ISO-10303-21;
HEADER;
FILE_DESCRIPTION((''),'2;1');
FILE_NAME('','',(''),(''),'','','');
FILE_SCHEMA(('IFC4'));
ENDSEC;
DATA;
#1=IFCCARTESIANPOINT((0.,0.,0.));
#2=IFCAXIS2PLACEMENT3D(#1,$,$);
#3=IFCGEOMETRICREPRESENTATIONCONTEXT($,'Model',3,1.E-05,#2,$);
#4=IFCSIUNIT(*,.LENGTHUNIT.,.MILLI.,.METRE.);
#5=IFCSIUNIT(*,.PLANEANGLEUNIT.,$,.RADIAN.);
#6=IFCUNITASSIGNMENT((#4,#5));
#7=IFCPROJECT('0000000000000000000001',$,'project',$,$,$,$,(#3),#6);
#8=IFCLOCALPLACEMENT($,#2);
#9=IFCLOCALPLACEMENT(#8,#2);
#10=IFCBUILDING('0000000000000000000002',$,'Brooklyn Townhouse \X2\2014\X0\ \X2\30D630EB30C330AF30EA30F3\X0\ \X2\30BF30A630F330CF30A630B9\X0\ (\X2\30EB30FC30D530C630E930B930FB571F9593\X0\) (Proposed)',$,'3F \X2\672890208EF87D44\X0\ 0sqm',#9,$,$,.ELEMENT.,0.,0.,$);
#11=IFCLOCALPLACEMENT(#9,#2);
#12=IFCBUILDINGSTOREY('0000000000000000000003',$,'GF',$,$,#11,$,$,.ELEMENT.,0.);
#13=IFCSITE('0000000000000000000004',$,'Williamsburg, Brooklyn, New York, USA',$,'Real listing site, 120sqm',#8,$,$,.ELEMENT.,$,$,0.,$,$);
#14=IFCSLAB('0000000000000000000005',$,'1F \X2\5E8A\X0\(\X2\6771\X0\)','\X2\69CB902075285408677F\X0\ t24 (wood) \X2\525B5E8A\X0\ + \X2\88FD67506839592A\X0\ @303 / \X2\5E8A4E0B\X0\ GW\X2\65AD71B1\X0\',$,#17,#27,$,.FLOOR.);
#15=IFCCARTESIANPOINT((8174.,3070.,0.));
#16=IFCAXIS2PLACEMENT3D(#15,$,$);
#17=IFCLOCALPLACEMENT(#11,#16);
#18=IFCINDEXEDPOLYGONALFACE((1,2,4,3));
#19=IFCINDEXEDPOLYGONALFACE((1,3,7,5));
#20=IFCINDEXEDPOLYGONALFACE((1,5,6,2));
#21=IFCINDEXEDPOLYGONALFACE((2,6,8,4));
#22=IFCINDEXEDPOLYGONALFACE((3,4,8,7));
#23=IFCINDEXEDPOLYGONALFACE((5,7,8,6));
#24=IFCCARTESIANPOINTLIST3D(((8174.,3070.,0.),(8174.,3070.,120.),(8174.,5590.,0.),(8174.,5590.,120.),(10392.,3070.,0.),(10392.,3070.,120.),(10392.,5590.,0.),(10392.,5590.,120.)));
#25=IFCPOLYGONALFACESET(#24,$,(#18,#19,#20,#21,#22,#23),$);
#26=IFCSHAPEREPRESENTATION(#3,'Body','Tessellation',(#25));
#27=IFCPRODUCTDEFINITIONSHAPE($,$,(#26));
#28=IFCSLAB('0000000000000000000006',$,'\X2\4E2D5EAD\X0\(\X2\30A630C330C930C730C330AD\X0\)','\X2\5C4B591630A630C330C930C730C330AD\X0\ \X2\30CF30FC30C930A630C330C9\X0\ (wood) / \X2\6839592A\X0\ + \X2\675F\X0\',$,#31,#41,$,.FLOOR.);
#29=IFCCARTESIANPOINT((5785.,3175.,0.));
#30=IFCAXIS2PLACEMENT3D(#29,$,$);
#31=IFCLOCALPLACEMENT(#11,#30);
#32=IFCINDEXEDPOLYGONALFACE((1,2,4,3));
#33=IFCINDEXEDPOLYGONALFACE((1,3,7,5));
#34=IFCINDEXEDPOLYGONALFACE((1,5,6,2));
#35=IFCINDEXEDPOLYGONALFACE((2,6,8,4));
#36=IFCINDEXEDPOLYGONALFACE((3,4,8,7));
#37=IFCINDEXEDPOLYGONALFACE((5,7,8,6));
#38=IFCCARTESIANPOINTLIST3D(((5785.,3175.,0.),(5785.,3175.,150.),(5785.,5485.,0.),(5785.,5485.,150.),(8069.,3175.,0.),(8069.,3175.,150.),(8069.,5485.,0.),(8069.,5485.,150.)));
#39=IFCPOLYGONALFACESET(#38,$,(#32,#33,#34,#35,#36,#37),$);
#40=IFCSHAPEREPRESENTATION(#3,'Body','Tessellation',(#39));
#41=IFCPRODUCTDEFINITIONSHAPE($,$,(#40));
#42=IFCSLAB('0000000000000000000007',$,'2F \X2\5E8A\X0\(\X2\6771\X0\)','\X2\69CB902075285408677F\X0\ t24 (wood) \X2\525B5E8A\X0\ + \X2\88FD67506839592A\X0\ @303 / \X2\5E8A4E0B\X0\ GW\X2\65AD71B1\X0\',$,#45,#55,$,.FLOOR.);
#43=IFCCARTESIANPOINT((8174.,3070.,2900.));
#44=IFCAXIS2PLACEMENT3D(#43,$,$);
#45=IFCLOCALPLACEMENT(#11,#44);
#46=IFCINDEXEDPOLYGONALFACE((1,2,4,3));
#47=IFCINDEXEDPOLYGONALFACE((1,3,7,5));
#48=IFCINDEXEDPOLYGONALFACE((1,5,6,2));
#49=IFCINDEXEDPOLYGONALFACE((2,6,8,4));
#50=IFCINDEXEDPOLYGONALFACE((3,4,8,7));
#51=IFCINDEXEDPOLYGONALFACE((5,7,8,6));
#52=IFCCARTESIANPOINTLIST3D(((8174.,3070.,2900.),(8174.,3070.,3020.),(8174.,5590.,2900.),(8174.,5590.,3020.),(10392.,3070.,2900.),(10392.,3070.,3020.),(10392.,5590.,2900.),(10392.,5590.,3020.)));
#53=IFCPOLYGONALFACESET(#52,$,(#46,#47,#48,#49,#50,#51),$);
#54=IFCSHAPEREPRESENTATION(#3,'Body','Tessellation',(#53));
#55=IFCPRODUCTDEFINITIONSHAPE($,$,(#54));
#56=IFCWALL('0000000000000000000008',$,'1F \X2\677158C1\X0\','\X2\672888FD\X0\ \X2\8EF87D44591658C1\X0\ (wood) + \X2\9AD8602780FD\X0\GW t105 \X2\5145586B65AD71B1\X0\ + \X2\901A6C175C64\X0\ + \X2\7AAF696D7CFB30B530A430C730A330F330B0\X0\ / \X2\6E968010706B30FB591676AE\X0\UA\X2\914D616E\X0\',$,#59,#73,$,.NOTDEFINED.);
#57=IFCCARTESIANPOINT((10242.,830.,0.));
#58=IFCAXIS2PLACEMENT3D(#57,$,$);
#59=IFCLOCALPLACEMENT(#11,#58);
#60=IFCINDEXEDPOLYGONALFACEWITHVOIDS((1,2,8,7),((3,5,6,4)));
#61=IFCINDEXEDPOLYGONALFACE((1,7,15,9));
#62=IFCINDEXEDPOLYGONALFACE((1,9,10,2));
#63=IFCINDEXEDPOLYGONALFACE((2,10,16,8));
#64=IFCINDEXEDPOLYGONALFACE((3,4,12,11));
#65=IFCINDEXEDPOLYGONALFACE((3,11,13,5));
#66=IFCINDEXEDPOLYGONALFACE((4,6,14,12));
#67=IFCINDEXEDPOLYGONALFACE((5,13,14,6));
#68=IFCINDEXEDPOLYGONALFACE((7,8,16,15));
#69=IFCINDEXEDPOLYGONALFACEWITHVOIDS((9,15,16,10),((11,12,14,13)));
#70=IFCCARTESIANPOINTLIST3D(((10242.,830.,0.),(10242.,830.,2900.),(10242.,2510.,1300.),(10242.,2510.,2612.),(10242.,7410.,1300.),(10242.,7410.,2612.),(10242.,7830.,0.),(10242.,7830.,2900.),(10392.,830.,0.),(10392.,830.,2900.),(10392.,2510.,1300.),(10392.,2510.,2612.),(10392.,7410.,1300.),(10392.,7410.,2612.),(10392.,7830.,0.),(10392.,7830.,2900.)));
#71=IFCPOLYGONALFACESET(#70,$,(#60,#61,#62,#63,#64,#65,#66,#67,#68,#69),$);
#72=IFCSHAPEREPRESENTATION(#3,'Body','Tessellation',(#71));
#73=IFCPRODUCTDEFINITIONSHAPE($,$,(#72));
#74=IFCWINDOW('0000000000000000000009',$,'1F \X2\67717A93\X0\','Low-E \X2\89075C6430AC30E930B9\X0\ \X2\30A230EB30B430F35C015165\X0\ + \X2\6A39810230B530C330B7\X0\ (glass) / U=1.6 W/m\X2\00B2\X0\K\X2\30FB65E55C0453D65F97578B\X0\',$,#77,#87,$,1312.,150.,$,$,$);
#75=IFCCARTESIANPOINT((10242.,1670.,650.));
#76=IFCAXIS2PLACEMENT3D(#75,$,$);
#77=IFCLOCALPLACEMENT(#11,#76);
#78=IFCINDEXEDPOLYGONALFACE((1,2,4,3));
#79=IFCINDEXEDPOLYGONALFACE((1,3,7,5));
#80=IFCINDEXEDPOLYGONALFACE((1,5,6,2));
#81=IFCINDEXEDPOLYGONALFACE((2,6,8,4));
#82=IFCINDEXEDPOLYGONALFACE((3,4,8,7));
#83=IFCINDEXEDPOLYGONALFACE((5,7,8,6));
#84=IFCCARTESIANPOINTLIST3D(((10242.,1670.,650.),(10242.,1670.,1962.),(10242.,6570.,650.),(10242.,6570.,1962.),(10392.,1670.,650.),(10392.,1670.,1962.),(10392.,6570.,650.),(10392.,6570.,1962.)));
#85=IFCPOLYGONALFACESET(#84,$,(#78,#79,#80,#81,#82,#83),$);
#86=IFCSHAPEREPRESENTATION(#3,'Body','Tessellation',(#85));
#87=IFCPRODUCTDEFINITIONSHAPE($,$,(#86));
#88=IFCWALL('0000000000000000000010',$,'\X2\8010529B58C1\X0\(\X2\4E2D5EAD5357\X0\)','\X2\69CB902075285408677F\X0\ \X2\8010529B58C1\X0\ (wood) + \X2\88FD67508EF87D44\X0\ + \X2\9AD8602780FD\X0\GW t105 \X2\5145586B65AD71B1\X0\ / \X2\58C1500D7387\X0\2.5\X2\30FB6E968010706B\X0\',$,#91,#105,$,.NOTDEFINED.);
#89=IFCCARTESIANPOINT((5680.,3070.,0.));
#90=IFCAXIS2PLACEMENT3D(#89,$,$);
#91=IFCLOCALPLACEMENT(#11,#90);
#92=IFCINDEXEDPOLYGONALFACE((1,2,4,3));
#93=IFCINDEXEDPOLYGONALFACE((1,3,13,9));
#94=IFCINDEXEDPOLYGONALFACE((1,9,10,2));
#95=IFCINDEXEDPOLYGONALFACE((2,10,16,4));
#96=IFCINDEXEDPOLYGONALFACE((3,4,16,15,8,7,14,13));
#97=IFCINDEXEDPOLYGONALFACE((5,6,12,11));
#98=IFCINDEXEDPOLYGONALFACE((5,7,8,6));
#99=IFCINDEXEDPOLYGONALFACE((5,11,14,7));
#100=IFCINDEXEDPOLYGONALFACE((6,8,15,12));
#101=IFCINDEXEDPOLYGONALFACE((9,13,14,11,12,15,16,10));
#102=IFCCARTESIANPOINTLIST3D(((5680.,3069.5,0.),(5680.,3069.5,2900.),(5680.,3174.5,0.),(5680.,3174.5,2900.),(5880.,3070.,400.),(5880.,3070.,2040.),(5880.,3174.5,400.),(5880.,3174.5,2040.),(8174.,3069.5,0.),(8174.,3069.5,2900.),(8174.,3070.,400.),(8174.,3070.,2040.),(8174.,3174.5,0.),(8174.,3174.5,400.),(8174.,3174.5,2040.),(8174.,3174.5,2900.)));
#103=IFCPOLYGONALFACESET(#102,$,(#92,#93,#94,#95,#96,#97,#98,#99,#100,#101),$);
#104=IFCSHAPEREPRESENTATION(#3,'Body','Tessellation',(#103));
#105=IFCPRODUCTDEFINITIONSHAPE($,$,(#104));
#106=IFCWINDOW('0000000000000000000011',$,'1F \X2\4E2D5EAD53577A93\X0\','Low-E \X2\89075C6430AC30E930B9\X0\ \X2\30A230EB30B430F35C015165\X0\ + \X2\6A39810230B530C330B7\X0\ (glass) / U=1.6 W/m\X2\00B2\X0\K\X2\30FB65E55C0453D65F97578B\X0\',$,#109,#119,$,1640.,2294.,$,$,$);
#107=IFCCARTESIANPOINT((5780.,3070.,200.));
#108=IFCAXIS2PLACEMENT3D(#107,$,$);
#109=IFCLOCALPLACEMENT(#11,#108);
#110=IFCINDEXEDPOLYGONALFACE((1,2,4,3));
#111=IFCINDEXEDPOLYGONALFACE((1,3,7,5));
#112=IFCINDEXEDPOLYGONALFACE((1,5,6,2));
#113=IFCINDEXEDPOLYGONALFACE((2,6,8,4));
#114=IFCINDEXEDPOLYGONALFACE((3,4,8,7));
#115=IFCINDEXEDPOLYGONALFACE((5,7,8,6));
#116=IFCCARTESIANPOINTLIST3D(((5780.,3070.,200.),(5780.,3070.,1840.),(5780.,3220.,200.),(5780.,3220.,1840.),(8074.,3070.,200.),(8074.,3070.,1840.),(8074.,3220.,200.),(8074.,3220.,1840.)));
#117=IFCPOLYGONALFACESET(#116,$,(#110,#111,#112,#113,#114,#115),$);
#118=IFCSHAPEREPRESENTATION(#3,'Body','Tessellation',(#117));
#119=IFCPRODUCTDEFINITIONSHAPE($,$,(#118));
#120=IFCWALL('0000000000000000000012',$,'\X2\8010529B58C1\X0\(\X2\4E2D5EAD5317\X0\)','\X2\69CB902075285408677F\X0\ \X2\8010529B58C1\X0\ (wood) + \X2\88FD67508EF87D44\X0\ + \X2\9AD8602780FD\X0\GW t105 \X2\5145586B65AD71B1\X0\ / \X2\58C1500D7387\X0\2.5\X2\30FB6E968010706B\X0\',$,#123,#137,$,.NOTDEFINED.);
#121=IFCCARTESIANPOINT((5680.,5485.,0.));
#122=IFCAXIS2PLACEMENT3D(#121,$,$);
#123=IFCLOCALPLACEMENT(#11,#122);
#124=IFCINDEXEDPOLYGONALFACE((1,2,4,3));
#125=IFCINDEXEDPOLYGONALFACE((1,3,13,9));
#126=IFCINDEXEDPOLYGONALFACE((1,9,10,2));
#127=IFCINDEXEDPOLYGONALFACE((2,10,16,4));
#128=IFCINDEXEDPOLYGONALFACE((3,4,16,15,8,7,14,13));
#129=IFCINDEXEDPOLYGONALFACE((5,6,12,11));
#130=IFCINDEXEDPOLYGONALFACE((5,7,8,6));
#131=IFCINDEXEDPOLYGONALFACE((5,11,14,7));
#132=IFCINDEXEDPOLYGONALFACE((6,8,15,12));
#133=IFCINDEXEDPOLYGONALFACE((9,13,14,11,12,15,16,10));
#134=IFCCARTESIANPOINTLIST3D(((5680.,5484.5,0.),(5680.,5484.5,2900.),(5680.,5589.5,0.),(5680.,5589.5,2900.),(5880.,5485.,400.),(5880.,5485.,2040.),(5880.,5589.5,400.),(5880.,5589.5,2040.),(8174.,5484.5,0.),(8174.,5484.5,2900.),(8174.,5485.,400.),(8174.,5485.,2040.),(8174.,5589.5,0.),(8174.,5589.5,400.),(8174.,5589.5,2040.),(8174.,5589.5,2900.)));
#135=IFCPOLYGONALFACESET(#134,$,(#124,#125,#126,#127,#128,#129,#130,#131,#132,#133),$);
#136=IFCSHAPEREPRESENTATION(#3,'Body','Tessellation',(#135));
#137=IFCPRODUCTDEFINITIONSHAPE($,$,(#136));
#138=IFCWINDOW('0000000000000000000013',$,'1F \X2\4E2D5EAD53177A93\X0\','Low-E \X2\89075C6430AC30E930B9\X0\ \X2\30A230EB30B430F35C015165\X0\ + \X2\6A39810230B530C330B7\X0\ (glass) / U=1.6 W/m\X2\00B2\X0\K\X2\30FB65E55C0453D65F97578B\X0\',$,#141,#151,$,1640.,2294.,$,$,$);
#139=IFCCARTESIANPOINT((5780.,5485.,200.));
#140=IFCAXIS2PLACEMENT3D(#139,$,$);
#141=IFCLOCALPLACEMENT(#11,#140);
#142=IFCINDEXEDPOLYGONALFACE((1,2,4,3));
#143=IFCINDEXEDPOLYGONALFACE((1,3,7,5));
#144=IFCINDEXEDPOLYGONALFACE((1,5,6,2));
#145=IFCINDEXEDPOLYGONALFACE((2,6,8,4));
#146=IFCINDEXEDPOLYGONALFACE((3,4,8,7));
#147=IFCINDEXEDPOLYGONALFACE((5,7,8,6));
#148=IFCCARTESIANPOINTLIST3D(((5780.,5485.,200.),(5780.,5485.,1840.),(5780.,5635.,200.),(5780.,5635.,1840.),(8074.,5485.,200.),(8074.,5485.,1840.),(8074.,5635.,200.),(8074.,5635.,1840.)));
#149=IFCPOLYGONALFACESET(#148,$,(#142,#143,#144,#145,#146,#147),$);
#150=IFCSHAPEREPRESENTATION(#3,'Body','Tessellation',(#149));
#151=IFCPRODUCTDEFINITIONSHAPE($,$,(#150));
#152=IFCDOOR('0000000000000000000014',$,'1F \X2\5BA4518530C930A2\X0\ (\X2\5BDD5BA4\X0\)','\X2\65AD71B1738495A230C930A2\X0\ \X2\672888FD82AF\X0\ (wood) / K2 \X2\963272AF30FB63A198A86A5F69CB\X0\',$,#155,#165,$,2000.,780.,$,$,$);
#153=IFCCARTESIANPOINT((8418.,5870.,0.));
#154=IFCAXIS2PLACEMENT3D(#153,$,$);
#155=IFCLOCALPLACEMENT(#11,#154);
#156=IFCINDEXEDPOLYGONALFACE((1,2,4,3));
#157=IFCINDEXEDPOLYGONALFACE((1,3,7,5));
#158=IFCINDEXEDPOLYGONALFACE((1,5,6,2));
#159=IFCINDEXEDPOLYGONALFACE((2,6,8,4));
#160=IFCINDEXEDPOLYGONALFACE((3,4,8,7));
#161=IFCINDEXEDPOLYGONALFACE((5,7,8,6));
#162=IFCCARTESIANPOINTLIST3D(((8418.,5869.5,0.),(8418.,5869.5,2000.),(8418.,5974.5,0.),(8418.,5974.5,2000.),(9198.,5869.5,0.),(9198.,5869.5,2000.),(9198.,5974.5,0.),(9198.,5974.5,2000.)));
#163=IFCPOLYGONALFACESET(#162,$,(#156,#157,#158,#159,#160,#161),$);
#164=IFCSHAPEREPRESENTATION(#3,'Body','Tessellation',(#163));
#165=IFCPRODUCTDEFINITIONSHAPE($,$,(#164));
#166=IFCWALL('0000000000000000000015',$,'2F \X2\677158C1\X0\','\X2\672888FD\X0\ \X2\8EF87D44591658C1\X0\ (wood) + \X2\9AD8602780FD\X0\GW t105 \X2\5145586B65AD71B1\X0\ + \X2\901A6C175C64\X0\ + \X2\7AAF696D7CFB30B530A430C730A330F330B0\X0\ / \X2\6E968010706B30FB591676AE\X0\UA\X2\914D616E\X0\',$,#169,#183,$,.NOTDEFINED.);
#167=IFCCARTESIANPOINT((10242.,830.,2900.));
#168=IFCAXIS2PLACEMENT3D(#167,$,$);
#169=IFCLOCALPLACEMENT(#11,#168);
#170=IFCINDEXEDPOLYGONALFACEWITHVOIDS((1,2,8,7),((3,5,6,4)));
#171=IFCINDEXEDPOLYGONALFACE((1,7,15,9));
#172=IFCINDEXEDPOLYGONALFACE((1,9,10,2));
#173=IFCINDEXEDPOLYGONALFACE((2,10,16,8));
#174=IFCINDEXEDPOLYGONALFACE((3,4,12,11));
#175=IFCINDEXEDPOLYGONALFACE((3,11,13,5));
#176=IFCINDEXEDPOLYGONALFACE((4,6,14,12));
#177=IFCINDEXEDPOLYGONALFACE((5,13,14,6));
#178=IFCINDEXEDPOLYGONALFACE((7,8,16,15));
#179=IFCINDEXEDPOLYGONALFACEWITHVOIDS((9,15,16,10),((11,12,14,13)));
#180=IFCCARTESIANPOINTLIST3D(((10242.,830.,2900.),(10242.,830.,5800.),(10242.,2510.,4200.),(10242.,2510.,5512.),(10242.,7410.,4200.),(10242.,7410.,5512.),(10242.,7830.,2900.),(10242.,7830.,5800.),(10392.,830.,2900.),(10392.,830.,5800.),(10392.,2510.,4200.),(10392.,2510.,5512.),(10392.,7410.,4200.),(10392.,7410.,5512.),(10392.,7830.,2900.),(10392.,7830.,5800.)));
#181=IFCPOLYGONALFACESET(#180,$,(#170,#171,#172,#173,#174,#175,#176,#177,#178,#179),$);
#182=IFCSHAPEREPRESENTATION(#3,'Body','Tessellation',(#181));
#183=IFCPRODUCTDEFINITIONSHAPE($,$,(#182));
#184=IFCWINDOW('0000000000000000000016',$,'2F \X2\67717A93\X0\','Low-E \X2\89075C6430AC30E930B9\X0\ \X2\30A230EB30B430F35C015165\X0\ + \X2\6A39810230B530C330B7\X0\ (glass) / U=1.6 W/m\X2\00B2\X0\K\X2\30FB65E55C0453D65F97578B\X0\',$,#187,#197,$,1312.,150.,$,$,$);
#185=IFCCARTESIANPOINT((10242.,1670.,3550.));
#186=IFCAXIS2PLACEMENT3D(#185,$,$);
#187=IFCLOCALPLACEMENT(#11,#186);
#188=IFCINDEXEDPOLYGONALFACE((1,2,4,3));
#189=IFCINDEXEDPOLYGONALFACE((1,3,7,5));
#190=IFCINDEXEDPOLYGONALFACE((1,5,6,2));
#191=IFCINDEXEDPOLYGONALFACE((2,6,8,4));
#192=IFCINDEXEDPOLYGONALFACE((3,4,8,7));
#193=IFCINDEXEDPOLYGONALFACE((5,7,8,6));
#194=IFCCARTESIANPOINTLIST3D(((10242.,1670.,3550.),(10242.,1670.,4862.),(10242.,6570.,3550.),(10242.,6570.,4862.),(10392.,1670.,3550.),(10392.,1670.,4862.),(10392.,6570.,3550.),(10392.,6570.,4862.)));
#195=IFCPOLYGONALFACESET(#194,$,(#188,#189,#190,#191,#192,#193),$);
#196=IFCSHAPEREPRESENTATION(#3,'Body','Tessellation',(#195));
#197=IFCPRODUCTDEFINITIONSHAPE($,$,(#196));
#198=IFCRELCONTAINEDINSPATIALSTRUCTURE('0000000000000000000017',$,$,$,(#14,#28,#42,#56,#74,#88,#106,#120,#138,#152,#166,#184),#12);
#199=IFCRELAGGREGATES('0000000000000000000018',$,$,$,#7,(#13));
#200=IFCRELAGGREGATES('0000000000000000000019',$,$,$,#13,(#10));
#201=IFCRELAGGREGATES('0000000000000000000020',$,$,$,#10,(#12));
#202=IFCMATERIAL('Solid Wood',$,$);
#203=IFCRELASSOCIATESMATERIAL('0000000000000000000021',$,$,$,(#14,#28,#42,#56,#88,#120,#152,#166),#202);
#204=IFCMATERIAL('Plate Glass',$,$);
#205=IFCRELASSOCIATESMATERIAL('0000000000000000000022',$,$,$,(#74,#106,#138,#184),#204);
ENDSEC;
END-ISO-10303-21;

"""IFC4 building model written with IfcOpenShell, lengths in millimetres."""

from ifc_helpers import new_model, si_unit, frame, frame_2d, origin, place, context, project, spatial, rectangle, extrude, material, element, fill, save


model = new_model("IFC4")

# Units and contexts
model_context = context("Model", 3, precision=1e-05, world=origin())
ifc_project = project(units=[si_unit("LENGTHUNIT", "METRE", prefix="MILLI"), si_unit("PLANEANGLEUNIT", "RADIAN")], contexts=[model_context])

# Site, building, storey
site_placement = place(None, origin())
site = spatial("IfcSite", under=ifc_project, at=site_placement, Name="Williamsburg, Brooklyn, New York, USA", ObjectType="Real listing site, 120sqm", CompositionType="ELEMENT", RefElevation=0.0)
building_placement = place(site_placement, origin())
building = spatial("IfcBuilding", under=site, at=building_placement, Name="Brooklyn Townhouse — ブルックリン タウンハウス (ルーフテラス・土間) (Proposed)", ObjectType="3F 木造軸組 0sqm", CompositionType="ELEMENT", ElevationOfRefHeight=0.0, ElevationOfTerrain=0.0)
storey_placement = place(building_placement, origin())
storey = spatial("IfcBuildingStorey", under=building, at=storey_placement, Name="GF", CompositionType="ELEMENT", Elevation=0.0)

# Slabs
ifc_material_1 = material(Name="Solid Wood")
slab_1_placement = place(storey_placement, frame((8174.0, 3070.0, 0.0)))
element("IfcSlab", 1, at=slab_1_placement, inside=storey, material=ifc_material_1, Name="1F 床(東)", Description="構造用合板 t24 (wood) 剛床 + 製材根太 @303 / 床下 GW断熱", PredefinedType="FLOOR", context=model_context, shape_type="SweptSolid", body=[
    extrude(rectangle(XDim=2218.0, YDim=2520.0, at=frame_2d((1109.0, 1260.0))), frame((8174.0, 3070.0, 0.0)), (0.0, 0.0, 1.0), 120.0),
])
slab_2_placement = place(storey_placement, frame((5785.0, 3175.0, 0.0)))
element("IfcSlab", 2, at=slab_2_placement, inside=storey, material=ifc_material_1, Name="中庭(ウッドデッキ)", Description="屋外ウッドデッキ ハードウッド (wood) / 根太 + 束", PredefinedType="FLOOR", context=model_context, shape_type="SweptSolid", body=[
    extrude(rectangle(XDim=2284.0, YDim=2310.0, at=frame_2d((1142.0, 1155.0))), frame((5785.0, 3175.0, 0.0)), (0.0, 0.0, 1.0), 150.0),
])
slab_3_placement = place(storey_placement, frame((8174.0, 3070.0, 2900.0)))
element("IfcSlab", 3, at=slab_3_placement, inside=storey, material=ifc_material_1, Name="2F 床(東)", Description="構造用合板 t24 (wood) 剛床 + 製材根太 @303 / 床下 GW断熱", PredefinedType="FLOOR", context=model_context, shape_type="SweptSolid", body=[
    extrude(rectangle(XDim=2218.0, YDim=2520.0, at=frame_2d((1109.0, 1260.0))), frame((8174.0, 3070.0, 2900.0)), (0.0, 0.0, 1.0), 120.0),
])

# Walls, openings, windows
wall_1_placement = place(storey_placement, frame((10242.0, 830.0, 0.0)))
wall_1 = element("IfcWall", 4, at=wall_1_placement, inside=storey, material=ifc_material_1, Name="1F 東壁", Description="木製 軸組外壁 (wood) + 高性能GW t105 充填断熱 + 通気層 + 窯業系サイディング / 準耐火・外皮UA配慮", PredefinedType="NOTDEFINED", context=model_context, shape_type="SweptSolid", body=[
    extrude(rectangle(XDim=150.0, YDim=7000.0, at=frame_2d((75.0, 3500.0))), frame((10242.0, 830.0, 0.0)), (0.0, 0.0, 1.0), 2900.0),
])
opening_1_placement = place(storey_placement, frame((10242.0, 1670.0, 650.0)))
opening_1 = element("IfcOpeningElement", 5, at=opening_1_placement, cuts=wall_1, PredefinedType="NOTDEFINED", context=model_context, shape_type="SweptSolid", body=[
    extrude(rectangle(XDim=150.0, YDim=4900.0, at=frame_2d((75.0, 2450.0))), frame((10242.0, 1670.0, 650.0)), (0.0, 0.0, 1.0), 1312.0),
])
ifc_material_2 = material(Name="Plate Glass")
window_1_placement = place(storey_placement, frame((10242.0, 1670.0, 650.0)))
window_1 = element("IfcWindow", 6, at=window_1_placement, inside=storey, material=ifc_material_2, Name="1F 東窓", Description="Low-E 複層ガラス アルゴン封入 + 樹脂サッシ (glass) / U=1.6 W/m²K・日射取得型", OverallHeight=1312.0, OverallWidth=150.0, context=model_context, shape_type="SweptSolid", body=[
    extrude(rectangle(XDim=150.0, YDim=4900.0, at=frame_2d((75.0, 2450.0))), frame((10242.0, 1670.0, 650.0)), (0.0, 0.0, 1.0), 1312.0),
])
fill(opening_1, window_1)
wall_2_placement = place(storey_placement, frame((5680.0, 3070.0, 0.0)))
wall_2 = element("IfcWall", 7, at=wall_2_placement, inside=storey, material=ifc_material_1, Name="耐力壁(中庭南)", Description="構造用合板 耐力壁 (wood) + 製材軸組 + 高性能GW t105 充填断熱 / 壁倍率2.5・準耐火", PredefinedType="NOTDEFINED", context=model_context, shape_type="SweptSolid", body=[
    extrude(rectangle(XDim=2494.0, YDim=105.0, at=frame_2d((1247.0, 52.0))), frame((5680.0, 3070.0, 0.0)), (0.0, 0.0, 1.0), 2900.0),
])
opening_2_placement = place(storey_placement, frame((5780.0, 3070.0, 200.0)))
opening_2 = element("IfcOpeningElement", 8, at=opening_2_placement, cuts=wall_2, PredefinedType="NOTDEFINED", context=model_context, shape_type="SweptSolid", body=[
    extrude(rectangle(XDim=2294.0, YDim=150.0, at=frame_2d((1147.0, 75.0))), frame((5780.0, 3070.0, 200.0)), (0.0, 0.0, 1.0), 1640.0),
])
window_2_placement = place(storey_placement, frame((5780.0, 3070.0, 200.0)))
window_2 = element("IfcWindow", 9, at=window_2_placement, inside=storey, material=ifc_material_2, Name="1F 中庭南窓", Description="Low-E 複層ガラス アルゴン封入 + 樹脂サッシ (glass) / U=1.6 W/m²K・日射取得型", OverallHeight=1640.0, OverallWidth=2294.0, context=model_context, shape_type="SweptSolid", body=[
    extrude(rectangle(XDim=2294.0, YDim=150.0, at=frame_2d((1147.0, 75.0))), frame((5780.0, 3070.0, 200.0)), (0.0, 0.0, 1.0), 1640.0),
])
fill(opening_2, window_2)
wall_3_placement = place(storey_placement, frame((5680.0, 5485.0, 0.0)))
wall_3 = element("IfcWall", 10, at=wall_3_placement, inside=storey, material=ifc_material_1, Name="耐力壁(中庭北)", Description="構造用合板 耐力壁 (wood) + 製材軸組 + 高性能GW t105 充填断熱 / 壁倍率2.5・準耐火", PredefinedType="NOTDEFINED", context=model_context, shape_type="SweptSolid", body=[
    extrude(rectangle(XDim=2494.0, YDim=105.0, at=frame_2d((1247.0, 52.0))), frame((5680.0, 5485.0, 0.0)), (0.0, 0.0, 1.0), 2900.0),
])
opening_3_placement = place(storey_placement, frame((5780.0, 5485.0, 200.0)))
opening_3 = element("IfcOpeningElement", 11, at=opening_3_placement, cuts=wall_3, PredefinedType="NOTDEFINED", context=model_context, shape_type="SweptSolid", body=[
    extrude(rectangle(XDim=2294.0, YDim=150.0, at=frame_2d((1147.0, 75.0))), frame((5780.0, 5485.0, 200.0)), (0.0, 0.0, 1.0), 1640.0),
])
window_3_placement = place(storey_placement, frame((5780.0, 5485.0, 200.0)))
window_3 = element("IfcWindow", 12, at=window_3_placement, inside=storey, material=ifc_material_2, Name="1F 中庭北窓", Description="Low-E 複層ガラス アルゴン封入 + 樹脂サッシ (glass) / U=1.6 W/m²K・日射取得型", OverallHeight=1640.0, OverallWidth=2294.0, context=model_context, shape_type="SweptSolid", body=[
    extrude(rectangle(XDim=2294.0, YDim=150.0, at=frame_2d((1147.0, 75.0))), frame((5780.0, 5485.0, 200.0)), (0.0, 0.0, 1.0), 1640.0),
])
fill(opening_3, window_3)

# Door
door_placement = place(storey_placement, frame((8418.0, 5870.0, 0.0)))
element("IfcDoor", 13, at=door_placement, inside=storey, material=ifc_material_1, Name="1F 室内ドア (寝室)", Description="断熱玄関ドア 木製芯 (wood) / K2 防犯・採風機構", OverallHeight=2000.0, OverallWidth=780.0, context=model_context, shape_type="SweptSolid", body=[
    extrude(rectangle(XDim=780.0, YDim=105.0, at=frame_2d((390.0, 52.0))), frame((8418.0, 5870.0, 0.0)), (0.0, 0.0, 1.0), 2000.0),
])

# Wall, opening, window
wall_4_placement = place(storey_placement, frame((10242.0, 830.0, 2900.0)))
wall_4 = element("IfcWall", 14, at=wall_4_placement, inside=storey, material=ifc_material_1, Name="2F 東壁", Description="木製 軸組外壁 (wood) + 高性能GW t105 充填断熱 + 通気層 + 窯業系サイディング / 準耐火・外皮UA配慮", PredefinedType="NOTDEFINED", context=model_context, shape_type="SweptSolid", body=[
    extrude(rectangle(XDim=150.0, YDim=7000.0, at=frame_2d((75.0, 3500.0))), frame((10242.0, 830.0, 2900.0)), (0.0, 0.0, 1.0), 2900.0),
])
opening_4_placement = place(storey_placement, frame((10242.0, 1670.0, 3550.0)))
opening_4 = element("IfcOpeningElement", 15, at=opening_4_placement, cuts=wall_4, PredefinedType="NOTDEFINED", context=model_context, shape_type="SweptSolid", body=[
    extrude(rectangle(XDim=150.0, YDim=4900.0, at=frame_2d((75.0, 2450.0))), frame((10242.0, 1670.0, 3550.0)), (0.0, 0.0, 1.0), 1312.0),
])
window_4_placement = place(storey_placement, frame((10242.0, 1670.0, 3550.0)))
window_4 = element("IfcWindow", 16, at=window_4_placement, inside=storey, material=ifc_material_2, Name="2F 東窓", Description="Low-E 複層ガラス アルゴン封入 + 樹脂サッシ (glass) / U=1.6 W/m²K・日射取得型", OverallHeight=1312.0, OverallWidth=150.0, context=model_context, shape_type="SweptSolid", body=[
    extrude(rectangle(XDim=150.0, YDim=4900.0, at=frame_2d((75.0, 2450.0))), frame((10242.0, 1670.0, 3550.0)), (0.0, 0.0, 1.0), 1312.0),
])
fill(opening_4, window_4)

save(model, "model.ifc")
